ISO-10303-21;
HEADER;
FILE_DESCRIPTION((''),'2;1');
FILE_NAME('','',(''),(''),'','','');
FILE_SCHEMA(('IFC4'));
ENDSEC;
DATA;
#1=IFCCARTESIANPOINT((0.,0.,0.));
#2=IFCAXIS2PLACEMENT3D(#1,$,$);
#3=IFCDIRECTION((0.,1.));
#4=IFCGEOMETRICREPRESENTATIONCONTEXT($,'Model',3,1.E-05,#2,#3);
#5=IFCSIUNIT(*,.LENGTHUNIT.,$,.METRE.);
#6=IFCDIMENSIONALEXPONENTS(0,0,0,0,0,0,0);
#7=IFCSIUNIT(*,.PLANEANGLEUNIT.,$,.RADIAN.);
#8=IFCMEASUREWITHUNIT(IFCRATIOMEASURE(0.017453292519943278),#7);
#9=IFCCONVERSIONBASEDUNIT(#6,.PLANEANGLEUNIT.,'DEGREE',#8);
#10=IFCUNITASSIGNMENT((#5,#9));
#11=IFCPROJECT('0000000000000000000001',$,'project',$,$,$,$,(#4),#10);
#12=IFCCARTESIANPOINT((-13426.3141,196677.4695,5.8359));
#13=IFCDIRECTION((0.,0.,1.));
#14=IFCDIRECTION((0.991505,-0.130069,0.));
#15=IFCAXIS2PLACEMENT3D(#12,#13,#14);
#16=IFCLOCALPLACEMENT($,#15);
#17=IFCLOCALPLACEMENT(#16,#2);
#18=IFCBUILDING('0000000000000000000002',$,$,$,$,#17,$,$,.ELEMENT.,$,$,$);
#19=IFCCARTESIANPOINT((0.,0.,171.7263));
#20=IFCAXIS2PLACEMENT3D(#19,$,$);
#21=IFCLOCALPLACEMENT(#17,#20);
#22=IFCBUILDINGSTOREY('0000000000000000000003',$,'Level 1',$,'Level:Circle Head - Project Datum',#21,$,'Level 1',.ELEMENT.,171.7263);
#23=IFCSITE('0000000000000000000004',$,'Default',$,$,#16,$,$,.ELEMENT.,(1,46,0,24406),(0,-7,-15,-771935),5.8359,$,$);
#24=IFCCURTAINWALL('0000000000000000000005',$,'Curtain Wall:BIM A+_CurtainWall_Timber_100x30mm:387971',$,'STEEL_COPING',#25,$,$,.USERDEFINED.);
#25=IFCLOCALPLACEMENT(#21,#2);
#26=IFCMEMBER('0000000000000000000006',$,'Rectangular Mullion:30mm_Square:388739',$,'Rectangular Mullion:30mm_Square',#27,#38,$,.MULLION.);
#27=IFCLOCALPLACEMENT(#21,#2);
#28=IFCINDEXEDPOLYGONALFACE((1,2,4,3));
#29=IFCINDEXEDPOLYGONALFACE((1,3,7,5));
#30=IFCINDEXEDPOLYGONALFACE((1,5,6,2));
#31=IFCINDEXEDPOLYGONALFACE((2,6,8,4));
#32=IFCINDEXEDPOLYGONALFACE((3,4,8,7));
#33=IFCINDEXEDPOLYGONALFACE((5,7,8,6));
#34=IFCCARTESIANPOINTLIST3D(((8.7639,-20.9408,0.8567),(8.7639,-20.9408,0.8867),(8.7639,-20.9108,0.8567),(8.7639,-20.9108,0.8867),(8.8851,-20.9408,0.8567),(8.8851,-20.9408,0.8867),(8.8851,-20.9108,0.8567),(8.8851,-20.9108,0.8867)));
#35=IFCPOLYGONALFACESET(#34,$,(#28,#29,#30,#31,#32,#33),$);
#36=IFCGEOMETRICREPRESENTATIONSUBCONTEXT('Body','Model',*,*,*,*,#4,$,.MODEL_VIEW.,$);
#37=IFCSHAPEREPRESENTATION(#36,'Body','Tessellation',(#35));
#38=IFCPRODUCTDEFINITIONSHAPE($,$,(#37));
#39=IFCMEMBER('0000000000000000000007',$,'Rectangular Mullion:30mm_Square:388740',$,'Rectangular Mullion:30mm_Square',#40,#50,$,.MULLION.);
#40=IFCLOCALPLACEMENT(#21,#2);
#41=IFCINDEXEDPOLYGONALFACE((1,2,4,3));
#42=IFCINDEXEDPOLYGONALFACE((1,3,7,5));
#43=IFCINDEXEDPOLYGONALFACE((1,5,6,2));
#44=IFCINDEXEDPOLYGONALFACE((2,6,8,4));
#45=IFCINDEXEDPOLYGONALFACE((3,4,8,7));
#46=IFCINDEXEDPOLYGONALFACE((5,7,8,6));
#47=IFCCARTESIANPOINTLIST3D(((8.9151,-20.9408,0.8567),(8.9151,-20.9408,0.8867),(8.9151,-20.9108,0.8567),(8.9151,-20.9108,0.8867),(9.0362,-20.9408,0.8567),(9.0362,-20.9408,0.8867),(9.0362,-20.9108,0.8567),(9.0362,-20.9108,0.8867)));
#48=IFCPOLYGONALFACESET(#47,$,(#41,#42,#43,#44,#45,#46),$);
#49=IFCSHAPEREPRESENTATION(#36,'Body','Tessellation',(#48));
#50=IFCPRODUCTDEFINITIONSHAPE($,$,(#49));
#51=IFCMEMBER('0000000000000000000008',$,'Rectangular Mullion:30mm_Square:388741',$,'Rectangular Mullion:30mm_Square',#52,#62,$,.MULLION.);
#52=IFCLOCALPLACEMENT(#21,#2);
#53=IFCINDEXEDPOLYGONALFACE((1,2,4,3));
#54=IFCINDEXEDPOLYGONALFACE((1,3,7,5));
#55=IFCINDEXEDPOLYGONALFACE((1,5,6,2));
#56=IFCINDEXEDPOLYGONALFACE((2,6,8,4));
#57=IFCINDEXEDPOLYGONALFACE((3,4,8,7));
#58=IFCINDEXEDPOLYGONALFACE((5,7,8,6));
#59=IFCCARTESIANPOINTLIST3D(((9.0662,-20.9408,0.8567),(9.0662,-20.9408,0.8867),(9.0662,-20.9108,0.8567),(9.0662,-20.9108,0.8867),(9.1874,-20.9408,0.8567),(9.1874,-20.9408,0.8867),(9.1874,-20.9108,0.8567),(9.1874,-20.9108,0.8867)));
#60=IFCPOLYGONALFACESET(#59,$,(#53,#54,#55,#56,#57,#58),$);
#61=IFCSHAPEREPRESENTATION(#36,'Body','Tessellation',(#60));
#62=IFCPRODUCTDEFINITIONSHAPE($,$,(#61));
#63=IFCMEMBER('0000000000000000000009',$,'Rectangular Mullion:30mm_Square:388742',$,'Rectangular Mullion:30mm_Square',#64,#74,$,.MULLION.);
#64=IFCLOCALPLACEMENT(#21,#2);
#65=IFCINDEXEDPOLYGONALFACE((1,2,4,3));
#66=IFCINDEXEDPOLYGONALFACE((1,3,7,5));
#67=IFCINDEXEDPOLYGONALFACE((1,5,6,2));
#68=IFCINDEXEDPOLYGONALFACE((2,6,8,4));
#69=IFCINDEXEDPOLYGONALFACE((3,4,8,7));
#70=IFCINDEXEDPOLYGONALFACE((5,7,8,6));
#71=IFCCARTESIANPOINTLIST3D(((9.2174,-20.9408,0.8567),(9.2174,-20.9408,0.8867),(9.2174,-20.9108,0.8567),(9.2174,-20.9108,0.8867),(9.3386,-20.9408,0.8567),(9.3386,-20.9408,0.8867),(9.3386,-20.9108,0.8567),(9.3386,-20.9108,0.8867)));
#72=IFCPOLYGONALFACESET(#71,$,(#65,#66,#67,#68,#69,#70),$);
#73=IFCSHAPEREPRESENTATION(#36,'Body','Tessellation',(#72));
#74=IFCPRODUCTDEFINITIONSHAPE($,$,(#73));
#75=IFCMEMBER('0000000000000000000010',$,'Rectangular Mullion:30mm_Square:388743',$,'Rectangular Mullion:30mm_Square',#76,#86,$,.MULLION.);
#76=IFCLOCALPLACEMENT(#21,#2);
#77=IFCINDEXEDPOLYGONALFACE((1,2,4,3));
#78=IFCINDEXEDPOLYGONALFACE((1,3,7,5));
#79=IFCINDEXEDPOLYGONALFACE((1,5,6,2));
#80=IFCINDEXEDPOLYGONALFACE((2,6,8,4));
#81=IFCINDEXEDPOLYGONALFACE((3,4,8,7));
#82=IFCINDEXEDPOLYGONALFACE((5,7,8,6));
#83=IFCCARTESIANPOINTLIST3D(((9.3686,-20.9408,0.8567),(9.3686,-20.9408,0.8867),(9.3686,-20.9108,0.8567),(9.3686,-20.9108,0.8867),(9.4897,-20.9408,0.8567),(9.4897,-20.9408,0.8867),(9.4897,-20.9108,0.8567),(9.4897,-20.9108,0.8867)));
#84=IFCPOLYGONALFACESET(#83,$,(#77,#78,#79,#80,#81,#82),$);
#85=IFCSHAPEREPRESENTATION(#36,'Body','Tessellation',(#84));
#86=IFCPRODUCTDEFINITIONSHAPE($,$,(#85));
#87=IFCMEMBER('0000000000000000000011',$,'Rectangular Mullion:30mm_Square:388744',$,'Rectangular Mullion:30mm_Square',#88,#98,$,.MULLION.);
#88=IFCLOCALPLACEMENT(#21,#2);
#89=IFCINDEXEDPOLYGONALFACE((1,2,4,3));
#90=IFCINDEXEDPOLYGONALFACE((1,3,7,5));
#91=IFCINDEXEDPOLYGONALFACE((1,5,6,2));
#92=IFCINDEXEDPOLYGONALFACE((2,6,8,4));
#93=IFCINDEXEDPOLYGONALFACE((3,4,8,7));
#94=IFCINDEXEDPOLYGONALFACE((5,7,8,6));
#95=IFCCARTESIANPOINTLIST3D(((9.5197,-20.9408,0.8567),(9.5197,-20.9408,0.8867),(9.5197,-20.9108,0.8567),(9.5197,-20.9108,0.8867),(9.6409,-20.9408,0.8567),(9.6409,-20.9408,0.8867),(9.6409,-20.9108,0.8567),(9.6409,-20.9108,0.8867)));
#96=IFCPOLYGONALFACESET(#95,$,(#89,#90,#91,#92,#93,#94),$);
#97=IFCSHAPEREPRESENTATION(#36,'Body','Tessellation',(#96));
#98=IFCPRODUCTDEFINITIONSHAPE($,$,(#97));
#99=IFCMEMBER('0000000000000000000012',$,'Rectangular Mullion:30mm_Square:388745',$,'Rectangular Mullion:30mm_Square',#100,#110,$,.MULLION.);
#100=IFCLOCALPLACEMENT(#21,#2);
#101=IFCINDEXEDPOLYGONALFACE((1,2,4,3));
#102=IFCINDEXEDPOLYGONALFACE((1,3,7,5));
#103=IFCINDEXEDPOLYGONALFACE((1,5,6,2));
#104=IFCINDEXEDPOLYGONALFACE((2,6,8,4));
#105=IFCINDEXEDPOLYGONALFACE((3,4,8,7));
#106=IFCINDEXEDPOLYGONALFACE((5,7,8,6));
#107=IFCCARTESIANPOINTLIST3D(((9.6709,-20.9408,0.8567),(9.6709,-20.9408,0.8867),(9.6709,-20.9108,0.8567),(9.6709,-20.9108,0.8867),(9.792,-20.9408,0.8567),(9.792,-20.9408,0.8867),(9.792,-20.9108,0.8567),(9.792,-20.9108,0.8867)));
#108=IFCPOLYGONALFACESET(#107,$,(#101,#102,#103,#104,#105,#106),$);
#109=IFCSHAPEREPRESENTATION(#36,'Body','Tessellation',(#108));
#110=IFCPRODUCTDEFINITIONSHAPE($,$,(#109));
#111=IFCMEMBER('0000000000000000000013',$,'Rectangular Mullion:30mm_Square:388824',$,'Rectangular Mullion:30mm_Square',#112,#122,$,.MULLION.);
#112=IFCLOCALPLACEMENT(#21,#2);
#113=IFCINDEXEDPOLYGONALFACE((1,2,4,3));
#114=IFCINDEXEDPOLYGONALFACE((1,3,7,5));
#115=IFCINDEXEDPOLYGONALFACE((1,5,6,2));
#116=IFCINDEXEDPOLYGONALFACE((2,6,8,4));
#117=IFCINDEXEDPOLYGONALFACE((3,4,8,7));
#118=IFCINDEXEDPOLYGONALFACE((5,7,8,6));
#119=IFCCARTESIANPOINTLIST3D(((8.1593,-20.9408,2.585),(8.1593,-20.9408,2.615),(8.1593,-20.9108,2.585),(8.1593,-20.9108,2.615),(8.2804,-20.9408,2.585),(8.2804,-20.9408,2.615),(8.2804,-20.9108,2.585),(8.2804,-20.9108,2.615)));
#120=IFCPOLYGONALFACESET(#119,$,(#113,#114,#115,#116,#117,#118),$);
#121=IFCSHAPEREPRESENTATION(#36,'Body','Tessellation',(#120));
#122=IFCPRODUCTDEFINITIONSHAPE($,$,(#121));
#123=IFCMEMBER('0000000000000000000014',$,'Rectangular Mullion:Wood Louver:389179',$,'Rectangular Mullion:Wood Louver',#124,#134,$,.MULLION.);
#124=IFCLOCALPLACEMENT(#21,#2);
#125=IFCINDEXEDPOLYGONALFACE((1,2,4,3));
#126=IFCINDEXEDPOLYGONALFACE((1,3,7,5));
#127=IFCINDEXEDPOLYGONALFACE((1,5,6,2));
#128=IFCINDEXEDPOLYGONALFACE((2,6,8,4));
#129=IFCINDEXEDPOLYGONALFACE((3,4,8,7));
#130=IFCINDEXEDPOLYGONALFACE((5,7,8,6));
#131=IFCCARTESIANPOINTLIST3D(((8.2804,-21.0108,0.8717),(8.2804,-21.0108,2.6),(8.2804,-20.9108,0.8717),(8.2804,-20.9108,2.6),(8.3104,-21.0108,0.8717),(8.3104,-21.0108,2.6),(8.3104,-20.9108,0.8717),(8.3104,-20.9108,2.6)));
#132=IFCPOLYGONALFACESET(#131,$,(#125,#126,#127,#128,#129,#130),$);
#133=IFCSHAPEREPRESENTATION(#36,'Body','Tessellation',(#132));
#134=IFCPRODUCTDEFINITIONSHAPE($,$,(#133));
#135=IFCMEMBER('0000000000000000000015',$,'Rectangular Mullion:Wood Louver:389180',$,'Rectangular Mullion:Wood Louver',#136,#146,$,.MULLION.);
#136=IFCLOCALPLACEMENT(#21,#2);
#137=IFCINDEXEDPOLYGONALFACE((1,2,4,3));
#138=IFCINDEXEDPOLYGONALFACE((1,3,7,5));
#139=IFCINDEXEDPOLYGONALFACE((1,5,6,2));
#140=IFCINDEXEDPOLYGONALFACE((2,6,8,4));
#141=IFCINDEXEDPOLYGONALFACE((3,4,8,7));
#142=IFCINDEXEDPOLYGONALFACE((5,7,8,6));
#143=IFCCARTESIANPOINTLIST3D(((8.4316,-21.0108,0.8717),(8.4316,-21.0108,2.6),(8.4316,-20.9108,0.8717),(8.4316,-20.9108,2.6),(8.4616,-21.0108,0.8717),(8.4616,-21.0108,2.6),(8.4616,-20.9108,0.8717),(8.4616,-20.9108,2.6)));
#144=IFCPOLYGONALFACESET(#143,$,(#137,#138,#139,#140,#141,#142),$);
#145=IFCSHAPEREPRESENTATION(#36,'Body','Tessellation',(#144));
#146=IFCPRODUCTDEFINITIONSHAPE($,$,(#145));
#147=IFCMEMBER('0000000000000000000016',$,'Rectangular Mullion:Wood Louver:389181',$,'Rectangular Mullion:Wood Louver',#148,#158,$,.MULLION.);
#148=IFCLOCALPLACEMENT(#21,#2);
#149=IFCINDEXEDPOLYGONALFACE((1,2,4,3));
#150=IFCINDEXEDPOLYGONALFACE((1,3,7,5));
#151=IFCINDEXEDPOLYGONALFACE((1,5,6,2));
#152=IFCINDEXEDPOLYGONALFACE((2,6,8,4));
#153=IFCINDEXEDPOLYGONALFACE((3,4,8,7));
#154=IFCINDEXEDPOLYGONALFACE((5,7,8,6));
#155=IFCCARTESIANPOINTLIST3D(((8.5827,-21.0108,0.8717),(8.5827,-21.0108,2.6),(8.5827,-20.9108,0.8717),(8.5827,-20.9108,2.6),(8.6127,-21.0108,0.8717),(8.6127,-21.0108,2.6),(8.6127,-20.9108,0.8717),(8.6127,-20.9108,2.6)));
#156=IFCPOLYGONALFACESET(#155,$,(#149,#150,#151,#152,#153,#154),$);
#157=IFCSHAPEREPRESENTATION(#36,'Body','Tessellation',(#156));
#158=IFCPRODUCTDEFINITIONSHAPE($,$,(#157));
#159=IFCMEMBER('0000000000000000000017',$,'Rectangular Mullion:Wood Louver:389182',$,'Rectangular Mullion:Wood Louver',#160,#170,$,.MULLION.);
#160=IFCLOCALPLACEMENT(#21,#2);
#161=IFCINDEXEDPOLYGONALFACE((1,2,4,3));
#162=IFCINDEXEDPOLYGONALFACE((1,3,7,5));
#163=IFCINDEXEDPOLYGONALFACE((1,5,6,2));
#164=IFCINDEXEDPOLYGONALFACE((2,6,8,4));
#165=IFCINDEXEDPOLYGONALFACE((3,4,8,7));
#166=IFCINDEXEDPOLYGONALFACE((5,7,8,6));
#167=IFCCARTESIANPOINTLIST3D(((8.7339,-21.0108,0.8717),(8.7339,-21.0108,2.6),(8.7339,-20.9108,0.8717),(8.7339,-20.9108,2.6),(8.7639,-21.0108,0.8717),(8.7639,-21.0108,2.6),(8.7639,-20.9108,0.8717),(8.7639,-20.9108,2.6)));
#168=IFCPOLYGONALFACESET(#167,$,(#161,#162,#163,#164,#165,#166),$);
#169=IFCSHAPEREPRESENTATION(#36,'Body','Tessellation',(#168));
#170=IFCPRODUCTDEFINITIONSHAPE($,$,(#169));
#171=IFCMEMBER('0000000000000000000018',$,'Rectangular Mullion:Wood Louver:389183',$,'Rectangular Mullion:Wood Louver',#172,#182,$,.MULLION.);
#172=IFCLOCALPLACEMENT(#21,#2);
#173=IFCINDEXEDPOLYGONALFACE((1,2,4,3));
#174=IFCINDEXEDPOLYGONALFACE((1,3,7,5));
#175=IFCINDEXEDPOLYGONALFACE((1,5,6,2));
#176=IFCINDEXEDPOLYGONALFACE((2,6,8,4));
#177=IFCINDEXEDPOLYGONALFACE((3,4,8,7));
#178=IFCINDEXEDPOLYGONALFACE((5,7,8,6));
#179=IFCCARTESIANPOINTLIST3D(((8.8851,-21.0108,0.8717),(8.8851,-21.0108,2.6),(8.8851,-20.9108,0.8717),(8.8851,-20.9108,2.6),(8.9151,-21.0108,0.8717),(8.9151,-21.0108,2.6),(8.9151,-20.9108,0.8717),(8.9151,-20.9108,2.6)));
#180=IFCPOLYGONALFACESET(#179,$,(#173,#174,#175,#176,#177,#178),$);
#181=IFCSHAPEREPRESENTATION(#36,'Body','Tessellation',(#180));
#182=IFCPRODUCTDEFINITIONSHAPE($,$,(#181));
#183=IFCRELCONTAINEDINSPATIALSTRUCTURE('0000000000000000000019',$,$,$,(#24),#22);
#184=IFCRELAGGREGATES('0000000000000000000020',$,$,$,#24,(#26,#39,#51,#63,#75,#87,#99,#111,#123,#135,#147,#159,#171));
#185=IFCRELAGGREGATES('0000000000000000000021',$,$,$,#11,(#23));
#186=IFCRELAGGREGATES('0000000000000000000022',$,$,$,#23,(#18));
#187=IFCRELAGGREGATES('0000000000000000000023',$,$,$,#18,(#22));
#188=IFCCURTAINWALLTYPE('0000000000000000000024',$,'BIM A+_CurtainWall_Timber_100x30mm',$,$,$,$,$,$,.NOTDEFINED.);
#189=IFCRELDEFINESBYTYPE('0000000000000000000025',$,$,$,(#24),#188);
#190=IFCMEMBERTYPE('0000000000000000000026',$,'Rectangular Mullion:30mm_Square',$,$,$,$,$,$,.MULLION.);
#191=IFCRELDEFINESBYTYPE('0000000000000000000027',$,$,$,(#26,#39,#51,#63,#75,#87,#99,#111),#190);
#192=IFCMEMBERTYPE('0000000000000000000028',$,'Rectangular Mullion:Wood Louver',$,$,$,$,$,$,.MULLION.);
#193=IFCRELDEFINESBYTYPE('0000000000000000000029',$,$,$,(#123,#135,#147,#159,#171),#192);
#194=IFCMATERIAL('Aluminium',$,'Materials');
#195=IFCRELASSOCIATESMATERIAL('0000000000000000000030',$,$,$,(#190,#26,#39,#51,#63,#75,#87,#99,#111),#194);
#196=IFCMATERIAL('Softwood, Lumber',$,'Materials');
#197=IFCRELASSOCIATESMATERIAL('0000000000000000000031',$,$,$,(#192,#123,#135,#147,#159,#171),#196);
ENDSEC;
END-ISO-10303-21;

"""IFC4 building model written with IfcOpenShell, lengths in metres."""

from ifc_helpers import new_model, entity, si_unit, converted_unit, direction, frame, origin, place, context, subcontext, project, spatial, indexed_curve, outline, extrude, source, transform, mapped, material, type_object, type_shapes, element, aggregate, save


model = new_model("IFC4")

# Units and contexts
model_context = context("Model", 3, precision=1e-05, world=origin(), true_north=direction((0.0, 1.0)))
body_context = subcontext(model_context, "Body", "Model", "MODEL_VIEW")
ifc_project = project(units=[si_unit("LENGTHUNIT", "METRE"), converted_unit("PLANEANGLEUNIT", "DEGREE", entity("IfcRatioMeasure", 0.017453292519943278), si_unit("PLANEANGLEUNIT", "RADIAN"), dimensions=[0, 0, 0, 0, 0, 0, 0])], contexts=[model_context])

# Site, building, storey
site_placement = place(None, frame((-13426.3141, 196677.4695, 5.8359), z_axis=(0.0, 0.0, 1.0), x_axis=(0.991505, -0.130069, 0.0)))
site = spatial("IfcSite", under=ifc_project, at=site_placement, Name="Default", CompositionType="ELEMENT", RefLatitude=(1, 46, 0, 24406), RefLongitude=(0, -7, -15, -771935), RefElevation=5.8359)
building_placement = place(site_placement, origin())
building = spatial("IfcBuilding", under=site, at=building_placement, CompositionType="ELEMENT")
storey_placement = place(building_placement, frame((0.0, 0.0, 171.7263)))
storey = spatial("IfcBuildingStorey", under=building, at=storey_placement, Name="Level 1", ObjectType="Level:Circle Head - Project Datum", LongName="Level 1", CompositionType="ELEMENT", Elevation=171.7263)

# Shared definitions
ifc_material_1 = material(Name="Aluminium", Category="Materials")

# Curtain wall, members
curtain_wall_type_1 = type_object("IfcCurtainWallType", Name="BIM A+_CurtainWall_Timber_100x30mm", PredefinedType="NOTDEFINED")
curtain_wall_1_placement = place(storey_placement, frame((0.0, 0.0, -171.7263)))
curtain_wall_1 = element("IfcCurtainWall", 1, at=curtain_wall_1_placement, inside=storey, type_object=curtain_wall_type_1, Name="Curtain Wall:BIM A+_CurtainWall_Timber_100x30mm:387971", ObjectType="STEEL_COPING", PredefinedType="USERDEFINED")
member_type_1 = type_object("IfcMemberType", Name="Rectangular Mullion:30mm_Square", PredefinedType="MULLION", material=ifc_material_1)
shared_shape_1 = source(origin(), body_context, "Body", "SweptSolid", [
    extrude(outline(indexed_curve([(-0.015, -0.015), (0.015, -0.015), (0.015, 0.015), (-0.015, 0.015), (-0.015, -0.015)], self_intersect=False)), frame((0.0, 0.0, -0.1212), z_axis=(0.0, 0.0, 1.0), x_axis=(0.0, -1.0, 0.0)), (0.0, 0.0, 1.0), 0.1212),
])
type_shapes(member_type_1, [shared_shape_1])
member_1_placement = place(curtain_wall_1_placement, frame((8.8851, -20.9258, 172.598), z_axis=(1.0, 0.0, 0.0), x_axis=(0.0, 0.0, 1.0)))
member_1 = element("IfcMember", 2, at=member_1_placement, type_object=member_type_1, material=ifc_material_1, Name="Rectangular Mullion:30mm_Square:388739", ObjectType="Rectangular Mullion:30mm_Square", PredefinedType="MULLION", context=body_context, shape_type="MappedRepresentation", body=[
    mapped(shared_shape_1, transform((0.0, 0.0, 0.0), scale=1.0)),
])
member_2_placement = place(curtain_wall_1_placement, frame((9.0362, -20.9258, 172.598), z_axis=(1.0, 0.0, 0.0), x_axis=(0.0, 0.0, 1.0)))
member_2 = element("IfcMember", 3, at=member_2_placement, type_object=member_type_1, material=ifc_material_1, Name="Rectangular Mullion:30mm_Square:388740", ObjectType="Rectangular Mullion:30mm_Square", PredefinedType="MULLION", context=body_context, shape_type="MappedRepresentation", body=[
    mapped(shared_shape_1, transform((0.0, 0.0, 0.0), scale=1.0)),
])
member_3_placement = place(curtain_wall_1_placement, frame((9.1874, -20.9258, 172.598), z_axis=(1.0, 0.0, 0.0), x_axis=(0.0, 0.0, 1.0)))
member_3 = element("IfcMember", 4, at=member_3_placement, type_object=member_type_1, material=ifc_material_1, Name="Rectangular Mullion:30mm_Square:388741", ObjectType="Rectangular Mullion:30mm_Square", PredefinedType="MULLION", context=body_context, shape_type="MappedRepresentation", body=[
    mapped(shared_shape_1, transform((0.0, 0.0, 0.0), scale=1.0)),
])
member_4_placement = place(curtain_wall_1_placement, frame((9.3386, -20.9258, 172.598), z_axis=(1.0, 0.0, 0.0), x_axis=(0.0, 0.0, 1.0)))
member_4 = element("IfcMember", 5, at=member_4_placement, type_object=member_type_1, material=ifc_material_1, Name="Rectangular Mullion:30mm_Square:388742", ObjectType="Rectangular Mullion:30mm_Square", PredefinedType="MULLION", context=body_context, shape_type="MappedRepresentation", body=[
    mapped(shared_shape_1, transform((0.0, 0.0, 0.0), scale=1.0)),
])
member_5_placement = place(curtain_wall_1_placement, frame((9.4897, -20.9258, 172.598), z_axis=(1.0, 0.0, 0.0), x_axis=(0.0, 0.0, 1.0)))
member_5 = element("IfcMember", 6, at=member_5_placement, type_object=member_type_1, material=ifc_material_1, Name="Rectangular Mullion:30mm_Square:388743", ObjectType="Rectangular Mullion:30mm_Square", PredefinedType="MULLION", context=body_context, shape_type="MappedRepresentation", body=[
    mapped(shared_shape_1, transform((0.0, 0.0, 0.0), scale=1.0)),
])
member_6_placement = place(curtain_wall_1_placement, frame((9.6409, -20.9258, 172.598), z_axis=(1.0, 0.0, 0.0), x_axis=(0.0, 0.0, 1.0)))
member_6 = element("IfcMember", 7, at=member_6_placement, type_object=member_type_1, material=ifc_material_1, Name="Rectangular Mullion:30mm_Square:388744", ObjectType="Rectangular Mullion:30mm_Square", PredefinedType="MULLION", context=body_context, shape_type="MappedRepresentation", body=[
    mapped(shared_shape_1, transform((0.0, 0.0, 0.0), scale=1.0)),
])
member_7_placement = place(curtain_wall_1_placement, frame((9.792, -20.9258, 172.598), z_axis=(1.0, 0.0, 0.0), x_axis=(0.0, 0.0, 1.0)))
member_7 = element("IfcMember", 8, at=member_7_placement, type_object=member_type_1, material=ifc_material_1, Name="Rectangular Mullion:30mm_Square:388745", ObjectType="Rectangular Mullion:30mm_Square", PredefinedType="MULLION", context=body_context, shape_type="MappedRepresentation", body=[
    mapped(shared_shape_1, transform((0.0, 0.0, 0.0), scale=1.0)),
])
member_8_placement = place(curtain_wall_1_placement, frame((8.2804, -20.9258, 174.3263), z_axis=(1.0, 0.0, 0.0), x_axis=(0.0, 0.0, 1.0)))
member_8 = element("IfcMember", 9, at=member_8_placement, type_object=member_type_1, material=ifc_material_1, Name="Rectangular Mullion:30mm_Square:388824", ObjectType="Rectangular Mullion:30mm_Square", PredefinedType="MULLION", context=body_context, shape_type="MappedRepresentation", body=[
    mapped(shared_shape_1, transform((0.0, 0.0, 0.0), scale=1.0)),
])
ifc_material_2 = material(Name="Softwood, Lumber", Category="Materials")
member_type_2 = type_object("IfcMemberType", Name="Rectangular Mullion:Wood Louver", PredefinedType="MULLION", material=ifc_material_2)
shared_shape_2 = source(origin(), body_context, "Body", "SweptSolid", [
    extrude(outline(indexed_curve([(-0.05, -0.015), (0.05, -0.015), (0.05, 0.015), (-0.05, 0.015), (-0.05, -0.015)], self_intersect=False)), frame((0.0, 0.035, -1.7283), z_axis=(0.0, 0.0, 1.0), x_axis=(0.0, -1.0, 0.0)), (0.0, 0.0, 1.0), 1.7283),
])
type_shapes(member_type_2, [shared_shape_2])
member_9_placement = place(curtain_wall_1_placement, frame((8.2954, -20.9258, 172.598), z_axis=(0.0, 0.0, -1.0), x_axis=(1.0, 0.0, 0.0)))
member_9 = element("IfcMember", 10, at=member_9_placement, type_object=member_type_2, material=ifc_material_2, Name="Rectangular Mullion:Wood Louver:389179", ObjectType="Rectangular Mullion:Wood Louver", PredefinedType="MULLION", context=body_context, shape_type="MappedRepresentation", body=[
    mapped(shared_shape_2, transform((0.0, 0.0, 0.0), scale=1.0)),
])
member_10_placement = place(curtain_wall_1_placement, frame((8.4466, -20.9258, 172.598), z_axis=(0.0, 0.0, -1.0), x_axis=(1.0, 0.0, 0.0)))
member_10 = element("IfcMember", 11, at=member_10_placement, type_object=member_type_2, material=ifc_material_2, Name="Rectangular Mullion:Wood Louver:389180", ObjectType="Rectangular Mullion:Wood Louver", PredefinedType="MULLION", context=body_context, shape_type="MappedRepresentation", body=[
    mapped(shared_shape_2, transform((0.0, 0.0, 0.0), scale=1.0)),
])
member_11_placement = place(curtain_wall_1_placement, frame((8.5977, -20.9258, 172.598), z_axis=(0.0, 0.0, -1.0), x_axis=(1.0, 0.0, 0.0)))
member_11 = element("IfcMember", 12, at=member_11_placement, type_object=member_type_2, material=ifc_material_2, Name="Rectangular Mullion:Wood Louver:389181", ObjectType="Rectangular Mullion:Wood Louver", PredefinedType="MULLION", context=body_context, shape_type="MappedRepresentation", body=[
    mapped(shared_shape_2, transform((0.0, 0.0, 0.0), scale=1.0)),
])
member_12_placement = place(curtain_wall_1_placement, frame((8.7489, -20.9258, 172.598), z_axis=(0.0, 0.0, -1.0), x_axis=(1.0, 0.0, 0.0)))
member_12 = element("IfcMember", 13, at=member_12_placement, type_object=member_type_2, material=ifc_material_2, Name="Rectangular Mullion:Wood Louver:389182", ObjectType="Rectangular Mullion:Wood Louver", PredefinedType="MULLION", context=body_context, shape_type="MappedRepresentation", body=[
    mapped(shared_shape_2, transform((0.0, 0.0, 0.0), scale=1.0)),
])
member_13_placement = place(curtain_wall_1_placement, frame((8.9001, -20.9258, 172.598), z_axis=(0.0, 0.0, -1.0), x_axis=(1.0, 0.0, 0.0)))
member_13 = element("IfcMember", 14, at=member_13_placement, type_object=member_type_2, material=ifc_material_2, Name="Rectangular Mullion:Wood Louver:389183", ObjectType="Rectangular Mullion:Wood Louver", PredefinedType="MULLION", context=body_context, shape_type="MappedRepresentation", body=[
    mapped(shared_shape_2, transform((0.0, 0.0, 0.0), scale=1.0)),
])

aggregate(curtain_wall_1, [member_1, member_2, member_3, member_4, member_5, member_6, member_7, member_8, member_9, member_10, member_11, member_12, member_13])

save(model, "model.ifc")
